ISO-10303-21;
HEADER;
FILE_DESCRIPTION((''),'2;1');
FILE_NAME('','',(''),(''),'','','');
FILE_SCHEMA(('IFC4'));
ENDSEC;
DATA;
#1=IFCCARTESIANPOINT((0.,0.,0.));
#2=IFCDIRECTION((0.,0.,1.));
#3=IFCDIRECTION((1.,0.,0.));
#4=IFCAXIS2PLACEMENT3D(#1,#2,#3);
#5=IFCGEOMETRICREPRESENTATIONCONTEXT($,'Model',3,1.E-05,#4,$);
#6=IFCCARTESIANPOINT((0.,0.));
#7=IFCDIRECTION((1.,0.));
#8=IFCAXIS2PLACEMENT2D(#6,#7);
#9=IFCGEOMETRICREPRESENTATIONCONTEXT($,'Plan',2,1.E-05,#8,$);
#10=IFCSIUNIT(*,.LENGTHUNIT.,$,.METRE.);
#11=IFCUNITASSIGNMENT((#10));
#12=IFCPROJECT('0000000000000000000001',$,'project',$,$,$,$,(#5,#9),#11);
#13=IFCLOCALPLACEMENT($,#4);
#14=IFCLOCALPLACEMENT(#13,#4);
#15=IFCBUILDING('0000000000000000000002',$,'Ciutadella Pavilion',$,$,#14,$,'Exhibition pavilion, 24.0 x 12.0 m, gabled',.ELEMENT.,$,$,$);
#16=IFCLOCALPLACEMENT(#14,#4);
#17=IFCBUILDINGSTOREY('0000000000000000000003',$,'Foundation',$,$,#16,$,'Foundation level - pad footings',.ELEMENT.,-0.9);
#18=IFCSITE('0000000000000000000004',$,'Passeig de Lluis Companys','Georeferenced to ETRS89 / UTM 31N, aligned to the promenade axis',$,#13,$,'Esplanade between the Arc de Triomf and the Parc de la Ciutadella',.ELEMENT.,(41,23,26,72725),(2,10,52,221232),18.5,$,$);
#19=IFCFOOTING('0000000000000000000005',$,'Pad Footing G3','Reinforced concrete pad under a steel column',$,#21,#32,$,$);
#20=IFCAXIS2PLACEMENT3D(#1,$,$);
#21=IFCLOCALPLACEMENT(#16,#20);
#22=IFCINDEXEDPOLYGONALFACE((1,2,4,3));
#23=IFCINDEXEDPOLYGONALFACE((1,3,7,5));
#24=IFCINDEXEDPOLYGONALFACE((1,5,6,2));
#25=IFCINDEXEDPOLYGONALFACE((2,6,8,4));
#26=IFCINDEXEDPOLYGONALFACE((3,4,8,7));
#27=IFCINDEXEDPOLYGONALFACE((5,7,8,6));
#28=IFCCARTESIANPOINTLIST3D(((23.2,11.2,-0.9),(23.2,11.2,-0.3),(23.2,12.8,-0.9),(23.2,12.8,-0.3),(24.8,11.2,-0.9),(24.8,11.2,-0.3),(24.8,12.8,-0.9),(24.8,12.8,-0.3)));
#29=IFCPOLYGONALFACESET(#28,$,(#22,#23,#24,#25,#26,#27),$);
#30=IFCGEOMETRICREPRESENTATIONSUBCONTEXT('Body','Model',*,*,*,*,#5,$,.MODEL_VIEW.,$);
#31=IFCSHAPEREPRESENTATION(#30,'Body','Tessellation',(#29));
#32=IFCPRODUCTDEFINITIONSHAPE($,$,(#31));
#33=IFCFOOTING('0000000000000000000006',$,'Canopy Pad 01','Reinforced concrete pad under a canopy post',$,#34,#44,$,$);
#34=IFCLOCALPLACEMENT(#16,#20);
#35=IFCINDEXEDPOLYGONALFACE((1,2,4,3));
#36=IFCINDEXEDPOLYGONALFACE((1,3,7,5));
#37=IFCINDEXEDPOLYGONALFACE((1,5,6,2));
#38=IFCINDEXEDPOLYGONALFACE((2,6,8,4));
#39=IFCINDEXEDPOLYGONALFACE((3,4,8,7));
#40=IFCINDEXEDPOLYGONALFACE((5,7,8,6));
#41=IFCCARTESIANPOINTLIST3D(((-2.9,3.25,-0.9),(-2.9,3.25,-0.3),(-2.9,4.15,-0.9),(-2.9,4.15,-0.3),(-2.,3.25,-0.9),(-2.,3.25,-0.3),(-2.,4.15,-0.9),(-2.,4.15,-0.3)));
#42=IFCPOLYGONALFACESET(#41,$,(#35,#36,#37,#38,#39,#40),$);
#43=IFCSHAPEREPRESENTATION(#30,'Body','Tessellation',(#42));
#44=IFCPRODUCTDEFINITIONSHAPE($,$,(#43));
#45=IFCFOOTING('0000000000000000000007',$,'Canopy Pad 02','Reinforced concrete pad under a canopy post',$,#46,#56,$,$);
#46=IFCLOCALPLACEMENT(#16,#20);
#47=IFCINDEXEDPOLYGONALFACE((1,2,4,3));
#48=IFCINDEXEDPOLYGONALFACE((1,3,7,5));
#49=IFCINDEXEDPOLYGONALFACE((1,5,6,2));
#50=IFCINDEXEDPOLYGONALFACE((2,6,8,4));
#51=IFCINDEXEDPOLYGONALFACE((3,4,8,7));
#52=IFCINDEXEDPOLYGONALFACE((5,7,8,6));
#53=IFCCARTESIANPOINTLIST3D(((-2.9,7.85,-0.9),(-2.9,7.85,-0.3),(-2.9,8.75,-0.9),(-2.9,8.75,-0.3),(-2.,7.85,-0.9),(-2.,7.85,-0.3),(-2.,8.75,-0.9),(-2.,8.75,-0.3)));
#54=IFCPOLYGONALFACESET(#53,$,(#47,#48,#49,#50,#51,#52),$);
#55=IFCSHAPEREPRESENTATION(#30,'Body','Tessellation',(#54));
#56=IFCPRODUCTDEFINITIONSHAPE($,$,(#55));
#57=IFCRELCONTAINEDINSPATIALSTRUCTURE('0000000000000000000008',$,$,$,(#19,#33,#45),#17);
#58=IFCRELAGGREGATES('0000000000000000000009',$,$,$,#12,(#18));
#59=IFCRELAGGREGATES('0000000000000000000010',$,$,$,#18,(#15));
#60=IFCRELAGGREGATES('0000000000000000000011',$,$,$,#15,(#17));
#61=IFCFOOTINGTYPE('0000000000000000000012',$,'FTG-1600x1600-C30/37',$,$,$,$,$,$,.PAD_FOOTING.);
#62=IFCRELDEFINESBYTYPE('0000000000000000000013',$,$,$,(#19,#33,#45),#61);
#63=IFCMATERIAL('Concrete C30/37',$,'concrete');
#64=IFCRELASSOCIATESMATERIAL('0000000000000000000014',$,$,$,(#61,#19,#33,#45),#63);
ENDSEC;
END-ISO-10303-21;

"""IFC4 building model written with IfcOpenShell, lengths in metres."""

from ifc_helpers import new_model, si_unit, frame, origin_with_axes, origin_2d_with_axis, place, context, subcontext, project, spatial, line, indexed_curve, outline, extrude, material, type_object, element, save


model = new_model("IFC4")

# Units and contexts
model_context = context("Model", 3, precision=1e-05, world=origin_with_axes())
plan_context = context("Plan", 2, precision=1e-05, world=origin_2d_with_axis())
body_context = subcontext(model_context, "Body", "Model", "MODEL_VIEW")
ifc_project = project(units=[si_unit("LENGTHUNIT", "METRE")], contexts=[model_context, plan_context])

# Site, building, storey
site_placement = place(None, origin_with_axes())
site = spatial("IfcSite", under=ifc_project, at=site_placement, Name="Passeig de Lluis Companys", Description="Georeferenced to ETRS89 / UTM 31N, aligned to the promenade axis", LongName="Esplanade between the Arc de Triomf and the Parc de la Ciutadella", CompositionType="ELEMENT", RefLatitude=(41, 23, 26, 72725), RefLongitude=(2, 10, 52, 221232), RefElevation=18.5)
building_placement = place(site_placement, origin_with_axes())
building = spatial("IfcBuilding", under=site, at=building_placement, Name="Ciutadella Pavilion", LongName="Exhibition pavilion, 24.0 x 12.0 m, gabled", CompositionType="ELEMENT")
storey_placement = place(building_placement, origin_with_axes())
storey = spatial("IfcBuildingStorey", under=building, at=storey_placement, Name="Foundation", LongName="Foundation level - pad footings", CompositionType="ELEMENT", Elevation=-0.9)

# Footings
ifc_material = material(Name="Concrete C30/37", Category="concrete")
footing_type = type_object("IfcFootingType", Name="FTG-1600x1600-C30/37", PredefinedType="PAD_FOOTING", material=ifc_material)
for number, where, z_axis, x_axis, name in (
    (1, (23.2, 11.2, -0.9), (0.0, 0.0, 1.0), (1.0, 0.0, 0.0), "Pad Footing G3"),
):
    element("IfcFooting", number, at=place(storey_placement, frame(where, z_axis=z_axis, x_axis=x_axis)), inside=storey, type_object=footing_type, material=ifc_material, Name=name, Description="Reinforced concrete pad under a steel column", context=body_context, shape_type="SweptSolid", body=[
        extrude(outline(indexed_curve([(0.0, 0.0), (1.6, 0.0), (1.6, 1.6), (0.0, 1.6)], segments=[line(1, 2, 3, 4, 1)])), origin_with_axes(), (0.0, 0.0, 1.0), 0.6),
    ])
for number, where, z_axis, x_axis, name in (
    (2, (-2.9, 3.25, -0.9), (0.0, 0.0, 1.0), (1.0, 0.0, 0.0), "Canopy Pad 01"),
    (3, (-2.9, 7.85, -0.9), (0.0, 0.0, 1.0), (1.0, 0.0, 0.0), "Canopy Pad 02"),
):
    element("IfcFooting", number, at=place(storey_placement, frame(where, z_axis=z_axis, x_axis=x_axis)), inside=storey, type_object=footing_type, material=ifc_material, Name=name, Description="Reinforced concrete pad under a canopy post", context=body_context, shape_type="SweptSolid", body=[
        extrude(outline(indexed_curve([(0.0, 0.0), (0.9, 0.0), (0.9, 0.9), (0.0, 0.9)], segments=[line(1, 2, 3, 4, 1)])), origin_with_axes(), (0.0, 0.0, 1.0), 0.6),
    ])

save(model, "model.ifc")
